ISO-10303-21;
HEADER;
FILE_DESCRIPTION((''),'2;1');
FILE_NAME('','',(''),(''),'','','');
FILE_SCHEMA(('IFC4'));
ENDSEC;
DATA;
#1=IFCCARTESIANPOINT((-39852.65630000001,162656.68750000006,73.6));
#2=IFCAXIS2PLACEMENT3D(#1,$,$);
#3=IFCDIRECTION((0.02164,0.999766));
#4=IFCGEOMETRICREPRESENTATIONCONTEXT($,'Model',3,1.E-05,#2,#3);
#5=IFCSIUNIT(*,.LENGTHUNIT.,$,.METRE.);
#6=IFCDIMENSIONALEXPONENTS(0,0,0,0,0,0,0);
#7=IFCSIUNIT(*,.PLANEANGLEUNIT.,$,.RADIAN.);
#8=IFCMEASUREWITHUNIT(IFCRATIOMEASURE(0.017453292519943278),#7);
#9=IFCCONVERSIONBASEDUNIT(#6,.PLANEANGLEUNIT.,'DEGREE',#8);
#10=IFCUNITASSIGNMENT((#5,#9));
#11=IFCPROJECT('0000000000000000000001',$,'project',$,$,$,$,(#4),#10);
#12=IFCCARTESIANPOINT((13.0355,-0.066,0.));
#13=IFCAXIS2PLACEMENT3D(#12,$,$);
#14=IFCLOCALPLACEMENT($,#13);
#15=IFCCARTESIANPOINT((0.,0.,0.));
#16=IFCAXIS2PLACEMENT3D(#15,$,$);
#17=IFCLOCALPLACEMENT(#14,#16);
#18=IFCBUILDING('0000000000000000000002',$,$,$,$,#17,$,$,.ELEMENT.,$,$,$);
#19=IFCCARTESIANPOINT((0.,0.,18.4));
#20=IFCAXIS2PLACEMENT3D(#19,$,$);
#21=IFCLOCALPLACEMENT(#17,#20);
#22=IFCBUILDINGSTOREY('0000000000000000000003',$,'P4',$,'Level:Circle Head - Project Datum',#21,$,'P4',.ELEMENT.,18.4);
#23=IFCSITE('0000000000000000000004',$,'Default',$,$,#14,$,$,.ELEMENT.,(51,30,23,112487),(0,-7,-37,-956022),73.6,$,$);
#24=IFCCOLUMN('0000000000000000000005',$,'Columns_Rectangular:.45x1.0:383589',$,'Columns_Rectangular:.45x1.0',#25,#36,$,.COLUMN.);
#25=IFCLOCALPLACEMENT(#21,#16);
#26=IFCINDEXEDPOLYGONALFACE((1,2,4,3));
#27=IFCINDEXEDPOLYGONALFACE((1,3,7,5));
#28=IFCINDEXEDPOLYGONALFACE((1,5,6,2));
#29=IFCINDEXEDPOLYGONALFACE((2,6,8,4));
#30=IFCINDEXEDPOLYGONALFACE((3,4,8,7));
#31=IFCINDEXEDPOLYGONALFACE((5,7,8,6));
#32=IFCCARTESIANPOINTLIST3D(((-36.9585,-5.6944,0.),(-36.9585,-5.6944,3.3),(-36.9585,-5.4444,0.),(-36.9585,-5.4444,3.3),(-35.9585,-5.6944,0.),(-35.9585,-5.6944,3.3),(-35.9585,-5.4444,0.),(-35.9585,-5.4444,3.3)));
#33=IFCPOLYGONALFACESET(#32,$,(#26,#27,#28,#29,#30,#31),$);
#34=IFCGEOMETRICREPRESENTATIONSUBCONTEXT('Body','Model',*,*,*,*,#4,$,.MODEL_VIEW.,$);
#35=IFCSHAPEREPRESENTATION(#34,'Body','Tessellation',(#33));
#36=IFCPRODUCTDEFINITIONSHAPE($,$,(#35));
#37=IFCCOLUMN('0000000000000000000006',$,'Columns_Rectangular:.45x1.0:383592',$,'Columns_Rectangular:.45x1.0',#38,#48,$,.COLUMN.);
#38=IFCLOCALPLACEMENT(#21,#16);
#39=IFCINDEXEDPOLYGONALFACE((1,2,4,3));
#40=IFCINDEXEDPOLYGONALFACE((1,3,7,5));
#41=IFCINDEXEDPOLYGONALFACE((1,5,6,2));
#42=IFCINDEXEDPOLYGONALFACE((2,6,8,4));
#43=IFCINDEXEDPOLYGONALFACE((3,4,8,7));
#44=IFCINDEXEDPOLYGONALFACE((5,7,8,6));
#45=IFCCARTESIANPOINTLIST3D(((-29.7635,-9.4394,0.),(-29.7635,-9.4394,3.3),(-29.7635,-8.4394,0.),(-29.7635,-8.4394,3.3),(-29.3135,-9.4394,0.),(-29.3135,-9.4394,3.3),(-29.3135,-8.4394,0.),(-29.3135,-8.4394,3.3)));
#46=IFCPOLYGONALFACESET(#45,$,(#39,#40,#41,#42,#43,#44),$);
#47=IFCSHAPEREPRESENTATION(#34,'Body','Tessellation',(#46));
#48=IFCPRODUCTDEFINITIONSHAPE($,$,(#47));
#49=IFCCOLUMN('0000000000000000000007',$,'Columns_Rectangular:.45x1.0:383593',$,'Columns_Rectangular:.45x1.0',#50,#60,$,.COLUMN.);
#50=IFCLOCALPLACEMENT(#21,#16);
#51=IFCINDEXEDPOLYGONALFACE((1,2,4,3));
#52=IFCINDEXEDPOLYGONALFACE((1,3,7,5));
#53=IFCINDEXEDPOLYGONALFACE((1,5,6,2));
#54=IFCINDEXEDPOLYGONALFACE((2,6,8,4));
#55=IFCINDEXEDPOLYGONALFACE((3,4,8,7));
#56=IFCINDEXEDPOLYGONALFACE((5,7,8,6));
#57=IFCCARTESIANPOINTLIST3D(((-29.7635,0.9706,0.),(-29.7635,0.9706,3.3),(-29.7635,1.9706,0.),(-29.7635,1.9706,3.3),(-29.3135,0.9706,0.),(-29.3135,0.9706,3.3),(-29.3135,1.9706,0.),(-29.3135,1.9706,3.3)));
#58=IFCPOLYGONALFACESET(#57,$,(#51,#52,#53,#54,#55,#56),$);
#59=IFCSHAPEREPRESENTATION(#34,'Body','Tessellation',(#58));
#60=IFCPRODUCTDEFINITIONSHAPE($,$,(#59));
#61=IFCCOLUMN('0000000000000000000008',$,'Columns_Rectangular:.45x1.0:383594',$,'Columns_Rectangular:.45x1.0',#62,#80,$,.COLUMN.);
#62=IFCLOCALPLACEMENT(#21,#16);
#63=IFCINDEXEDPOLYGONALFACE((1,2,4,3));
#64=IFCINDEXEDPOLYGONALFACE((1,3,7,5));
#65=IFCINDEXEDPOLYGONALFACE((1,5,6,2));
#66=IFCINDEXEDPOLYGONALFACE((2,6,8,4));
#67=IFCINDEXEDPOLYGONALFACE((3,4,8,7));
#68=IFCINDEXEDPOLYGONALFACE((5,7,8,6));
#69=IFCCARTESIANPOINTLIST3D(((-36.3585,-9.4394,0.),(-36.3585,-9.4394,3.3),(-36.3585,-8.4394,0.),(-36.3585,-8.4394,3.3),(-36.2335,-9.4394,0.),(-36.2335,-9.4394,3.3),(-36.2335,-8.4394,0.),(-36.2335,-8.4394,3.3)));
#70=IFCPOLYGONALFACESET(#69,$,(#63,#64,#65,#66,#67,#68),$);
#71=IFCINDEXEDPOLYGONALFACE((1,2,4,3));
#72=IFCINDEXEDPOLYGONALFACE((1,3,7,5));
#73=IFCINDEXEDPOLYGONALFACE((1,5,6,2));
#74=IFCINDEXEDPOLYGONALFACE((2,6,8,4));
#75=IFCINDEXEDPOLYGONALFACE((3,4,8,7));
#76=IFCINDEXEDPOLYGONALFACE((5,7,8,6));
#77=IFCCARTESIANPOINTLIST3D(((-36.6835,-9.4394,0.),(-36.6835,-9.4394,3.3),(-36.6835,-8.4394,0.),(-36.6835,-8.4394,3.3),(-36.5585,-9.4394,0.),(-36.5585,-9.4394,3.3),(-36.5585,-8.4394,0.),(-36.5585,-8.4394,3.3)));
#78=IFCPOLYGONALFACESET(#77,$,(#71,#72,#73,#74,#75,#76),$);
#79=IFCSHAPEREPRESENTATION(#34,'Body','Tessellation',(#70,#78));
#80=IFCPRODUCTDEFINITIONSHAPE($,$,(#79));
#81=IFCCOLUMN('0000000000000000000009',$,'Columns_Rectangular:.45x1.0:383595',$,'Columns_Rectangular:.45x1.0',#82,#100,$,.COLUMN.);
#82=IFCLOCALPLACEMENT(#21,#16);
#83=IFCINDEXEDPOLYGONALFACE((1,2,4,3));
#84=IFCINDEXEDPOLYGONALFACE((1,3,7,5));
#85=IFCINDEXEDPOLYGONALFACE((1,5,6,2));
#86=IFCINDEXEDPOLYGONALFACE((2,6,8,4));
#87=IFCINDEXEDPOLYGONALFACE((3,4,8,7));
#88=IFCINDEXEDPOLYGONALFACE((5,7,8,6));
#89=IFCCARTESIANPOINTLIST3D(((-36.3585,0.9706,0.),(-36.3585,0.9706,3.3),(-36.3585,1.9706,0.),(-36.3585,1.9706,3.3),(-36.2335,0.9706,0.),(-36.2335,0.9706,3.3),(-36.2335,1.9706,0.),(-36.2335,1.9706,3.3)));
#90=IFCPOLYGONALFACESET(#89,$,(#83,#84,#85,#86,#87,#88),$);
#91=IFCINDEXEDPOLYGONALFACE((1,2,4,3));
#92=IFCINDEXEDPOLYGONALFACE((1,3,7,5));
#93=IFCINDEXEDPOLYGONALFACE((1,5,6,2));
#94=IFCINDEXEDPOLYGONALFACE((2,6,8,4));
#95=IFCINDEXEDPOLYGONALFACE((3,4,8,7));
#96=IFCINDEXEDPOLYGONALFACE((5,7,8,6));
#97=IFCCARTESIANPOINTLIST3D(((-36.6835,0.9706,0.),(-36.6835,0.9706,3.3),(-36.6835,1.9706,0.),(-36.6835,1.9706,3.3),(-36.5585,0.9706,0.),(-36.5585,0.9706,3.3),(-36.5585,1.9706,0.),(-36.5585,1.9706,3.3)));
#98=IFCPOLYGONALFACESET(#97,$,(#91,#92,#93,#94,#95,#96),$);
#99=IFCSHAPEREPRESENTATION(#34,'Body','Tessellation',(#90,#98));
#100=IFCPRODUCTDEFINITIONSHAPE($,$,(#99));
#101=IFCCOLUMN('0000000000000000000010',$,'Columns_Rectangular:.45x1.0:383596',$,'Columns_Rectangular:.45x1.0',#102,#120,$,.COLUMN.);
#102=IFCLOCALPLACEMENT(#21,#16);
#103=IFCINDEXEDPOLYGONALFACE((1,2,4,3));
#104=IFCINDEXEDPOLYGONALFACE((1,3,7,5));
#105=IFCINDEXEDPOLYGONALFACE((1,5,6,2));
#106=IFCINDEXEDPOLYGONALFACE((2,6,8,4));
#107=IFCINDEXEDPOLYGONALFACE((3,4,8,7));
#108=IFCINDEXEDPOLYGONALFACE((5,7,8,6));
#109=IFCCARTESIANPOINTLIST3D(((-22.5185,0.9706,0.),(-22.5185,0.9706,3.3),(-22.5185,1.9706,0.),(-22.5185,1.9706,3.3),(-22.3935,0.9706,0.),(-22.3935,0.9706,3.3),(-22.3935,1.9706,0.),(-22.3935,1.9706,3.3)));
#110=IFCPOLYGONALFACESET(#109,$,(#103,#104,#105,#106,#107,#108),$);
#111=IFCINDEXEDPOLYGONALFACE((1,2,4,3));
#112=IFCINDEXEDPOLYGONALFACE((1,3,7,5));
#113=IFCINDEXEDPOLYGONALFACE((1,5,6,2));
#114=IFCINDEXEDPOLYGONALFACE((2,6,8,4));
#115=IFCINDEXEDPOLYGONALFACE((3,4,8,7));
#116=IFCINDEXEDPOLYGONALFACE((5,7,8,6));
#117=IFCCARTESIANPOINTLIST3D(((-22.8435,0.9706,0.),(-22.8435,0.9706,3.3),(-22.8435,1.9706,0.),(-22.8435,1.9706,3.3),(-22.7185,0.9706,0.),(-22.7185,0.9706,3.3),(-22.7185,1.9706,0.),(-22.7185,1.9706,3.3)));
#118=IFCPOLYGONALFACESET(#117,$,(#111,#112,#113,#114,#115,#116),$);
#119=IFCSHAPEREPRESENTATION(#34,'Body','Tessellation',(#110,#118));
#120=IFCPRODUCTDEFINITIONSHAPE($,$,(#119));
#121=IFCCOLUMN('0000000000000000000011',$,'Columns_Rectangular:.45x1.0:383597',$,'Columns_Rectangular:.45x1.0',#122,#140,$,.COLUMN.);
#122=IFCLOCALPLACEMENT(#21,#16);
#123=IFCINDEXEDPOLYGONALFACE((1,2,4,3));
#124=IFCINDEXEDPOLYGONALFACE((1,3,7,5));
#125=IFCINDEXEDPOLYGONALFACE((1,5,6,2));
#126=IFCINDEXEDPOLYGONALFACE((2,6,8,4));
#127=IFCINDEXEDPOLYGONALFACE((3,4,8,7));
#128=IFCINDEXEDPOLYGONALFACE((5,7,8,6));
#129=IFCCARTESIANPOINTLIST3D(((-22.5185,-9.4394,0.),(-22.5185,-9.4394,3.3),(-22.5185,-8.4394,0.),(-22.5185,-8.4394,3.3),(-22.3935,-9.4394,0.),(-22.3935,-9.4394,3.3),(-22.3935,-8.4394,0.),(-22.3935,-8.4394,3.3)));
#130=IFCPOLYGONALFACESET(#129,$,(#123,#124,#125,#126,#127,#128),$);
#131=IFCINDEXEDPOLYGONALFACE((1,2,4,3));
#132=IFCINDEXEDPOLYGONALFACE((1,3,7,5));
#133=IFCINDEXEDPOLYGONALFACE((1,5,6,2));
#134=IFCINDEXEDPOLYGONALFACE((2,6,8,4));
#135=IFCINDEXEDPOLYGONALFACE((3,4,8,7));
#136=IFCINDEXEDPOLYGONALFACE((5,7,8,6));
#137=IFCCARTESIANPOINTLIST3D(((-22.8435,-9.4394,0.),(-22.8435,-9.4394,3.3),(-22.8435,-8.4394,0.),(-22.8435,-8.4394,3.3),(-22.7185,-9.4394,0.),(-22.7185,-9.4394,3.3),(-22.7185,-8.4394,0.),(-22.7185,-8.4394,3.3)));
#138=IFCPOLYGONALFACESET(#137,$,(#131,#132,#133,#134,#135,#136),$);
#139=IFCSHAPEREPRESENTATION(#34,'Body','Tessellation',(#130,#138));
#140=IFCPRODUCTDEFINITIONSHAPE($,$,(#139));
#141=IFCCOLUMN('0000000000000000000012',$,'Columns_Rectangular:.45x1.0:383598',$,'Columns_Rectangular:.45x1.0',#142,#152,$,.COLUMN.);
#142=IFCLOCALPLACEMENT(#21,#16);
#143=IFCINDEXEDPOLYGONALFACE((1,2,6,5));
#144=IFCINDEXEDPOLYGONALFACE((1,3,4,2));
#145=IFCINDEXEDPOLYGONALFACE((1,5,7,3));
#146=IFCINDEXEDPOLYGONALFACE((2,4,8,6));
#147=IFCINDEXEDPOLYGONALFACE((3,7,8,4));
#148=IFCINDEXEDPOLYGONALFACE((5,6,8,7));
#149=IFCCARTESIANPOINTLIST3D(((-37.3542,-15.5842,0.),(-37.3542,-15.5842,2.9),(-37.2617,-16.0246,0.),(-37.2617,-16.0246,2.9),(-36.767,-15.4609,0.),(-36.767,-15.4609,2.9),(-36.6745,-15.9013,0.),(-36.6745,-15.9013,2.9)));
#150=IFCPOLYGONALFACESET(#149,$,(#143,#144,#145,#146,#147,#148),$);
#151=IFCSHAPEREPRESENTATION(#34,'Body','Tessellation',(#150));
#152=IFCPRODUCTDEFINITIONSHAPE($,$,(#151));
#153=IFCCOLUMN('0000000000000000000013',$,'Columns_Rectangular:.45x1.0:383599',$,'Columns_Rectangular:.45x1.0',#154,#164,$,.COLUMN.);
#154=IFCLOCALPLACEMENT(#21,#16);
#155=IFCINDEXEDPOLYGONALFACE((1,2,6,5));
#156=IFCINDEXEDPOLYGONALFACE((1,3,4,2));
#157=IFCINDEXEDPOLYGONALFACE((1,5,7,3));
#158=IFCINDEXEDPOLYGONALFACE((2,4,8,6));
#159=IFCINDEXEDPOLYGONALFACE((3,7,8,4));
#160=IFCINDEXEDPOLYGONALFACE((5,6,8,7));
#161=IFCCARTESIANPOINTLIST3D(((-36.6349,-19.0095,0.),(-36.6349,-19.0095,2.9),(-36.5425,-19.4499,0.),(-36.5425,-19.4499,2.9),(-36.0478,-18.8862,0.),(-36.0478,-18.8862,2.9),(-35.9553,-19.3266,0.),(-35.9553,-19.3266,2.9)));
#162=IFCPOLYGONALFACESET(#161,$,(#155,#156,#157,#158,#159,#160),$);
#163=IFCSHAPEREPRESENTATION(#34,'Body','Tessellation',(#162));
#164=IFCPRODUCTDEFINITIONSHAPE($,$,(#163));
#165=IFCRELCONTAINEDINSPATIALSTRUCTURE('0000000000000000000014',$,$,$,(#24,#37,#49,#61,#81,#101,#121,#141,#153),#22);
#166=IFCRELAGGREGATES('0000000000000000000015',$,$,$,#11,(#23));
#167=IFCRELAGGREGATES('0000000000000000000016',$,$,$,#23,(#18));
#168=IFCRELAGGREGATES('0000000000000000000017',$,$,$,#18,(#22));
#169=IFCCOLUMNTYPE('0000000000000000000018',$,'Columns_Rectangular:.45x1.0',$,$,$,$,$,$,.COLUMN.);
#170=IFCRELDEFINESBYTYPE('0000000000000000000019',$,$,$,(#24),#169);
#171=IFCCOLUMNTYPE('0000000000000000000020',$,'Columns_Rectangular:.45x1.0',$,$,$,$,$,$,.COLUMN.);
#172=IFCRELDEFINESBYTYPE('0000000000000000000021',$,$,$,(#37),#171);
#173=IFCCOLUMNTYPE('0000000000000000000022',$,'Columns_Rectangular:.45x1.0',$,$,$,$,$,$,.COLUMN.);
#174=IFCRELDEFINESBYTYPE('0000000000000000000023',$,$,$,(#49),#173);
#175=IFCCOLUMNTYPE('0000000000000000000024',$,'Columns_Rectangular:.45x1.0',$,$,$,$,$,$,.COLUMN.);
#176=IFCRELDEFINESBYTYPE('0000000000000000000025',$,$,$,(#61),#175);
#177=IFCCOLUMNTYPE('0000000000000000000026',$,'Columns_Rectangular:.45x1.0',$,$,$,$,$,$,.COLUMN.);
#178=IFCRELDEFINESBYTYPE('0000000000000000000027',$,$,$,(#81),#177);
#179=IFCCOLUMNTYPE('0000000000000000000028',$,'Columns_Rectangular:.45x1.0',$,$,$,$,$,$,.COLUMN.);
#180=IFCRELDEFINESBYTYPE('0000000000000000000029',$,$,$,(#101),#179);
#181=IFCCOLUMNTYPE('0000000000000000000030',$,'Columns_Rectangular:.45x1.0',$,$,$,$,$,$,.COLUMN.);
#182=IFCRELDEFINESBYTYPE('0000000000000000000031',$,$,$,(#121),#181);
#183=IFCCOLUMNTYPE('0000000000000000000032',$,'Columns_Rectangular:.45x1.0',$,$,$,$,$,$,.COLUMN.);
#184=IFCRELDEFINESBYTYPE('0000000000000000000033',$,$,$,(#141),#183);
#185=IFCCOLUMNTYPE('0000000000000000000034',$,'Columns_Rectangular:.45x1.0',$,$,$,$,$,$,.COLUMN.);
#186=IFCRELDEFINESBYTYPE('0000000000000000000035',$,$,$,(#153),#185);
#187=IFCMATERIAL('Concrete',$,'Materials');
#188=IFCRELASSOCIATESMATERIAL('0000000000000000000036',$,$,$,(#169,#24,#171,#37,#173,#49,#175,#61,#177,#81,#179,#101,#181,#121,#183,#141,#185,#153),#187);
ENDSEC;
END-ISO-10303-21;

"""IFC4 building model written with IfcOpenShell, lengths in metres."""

from ifc_helpers import new_model, entity, si_unit, converted_unit, direction, frame, origin, place, context, subcontext, project, spatial, indexed_curve, outline, extrude, source, transform, mapped, material, type_object, type_shapes, element, save


model = new_model("IFC4")

# Units and contexts
model_context = context("Model", 3, precision=1e-05, world=frame((-39852.65630000001, 162656.68750000006, 73.6)), true_north=direction((0.02164, 0.999766)))
body_context = subcontext(model_context, "Body", "Model", "MODEL_VIEW")
ifc_project = project(units=[si_unit("LENGTHUNIT", "METRE"), converted_unit("PLANEANGLEUNIT", "DEGREE", entity("IfcRatioMeasure", 0.017453292519943278), si_unit("PLANEANGLEUNIT", "RADIAN"), dimensions=[0, 0, 0, 0, 0, 0, 0])], contexts=[model_context])

# Site, building, storey
site_placement = place(None, frame((13.0355, -0.066, 0.0)))
site = spatial("IfcSite", under=ifc_project, at=site_placement, Name="Default", CompositionType="ELEMENT", RefLatitude=(51, 30, 23, 112487), RefLongitude=(0, -7, -37, -956022), RefElevation=73.6)
building_placement = place(site_placement, origin())
building = spatial("IfcBuilding", under=site, at=building_placement, CompositionType="ELEMENT")
storey_placement = place(building_placement, frame((0.0, 0.0, 18.4)))
storey = spatial("IfcBuildingStorey", under=building, at=storey_placement, Name="P4", ObjectType="Level:Circle Head - Project Datum", LongName="P4", CompositionType="ELEMENT", Elevation=18.4)

# Columns
ifc_material = material(Name="Concrete", Category="Materials")
column_type_1 = type_object("IfcColumnType", Name="Columns_Rectangular:.45x1.0", PredefinedType="COLUMN", material=ifc_material)
shared_shape_1 = source(origin(), body_context, "Body", "SweptSolid", [
    extrude(outline(indexed_curve([(-0.125, -0.5), (0.125, -0.5), (0.125, 0.5), (-0.125, 0.5), (-0.125, -0.5)], self_intersect=False)), frame((-36.4585, -5.5694, 18.4), z_axis=(0.0, 0.0, 1.0), x_axis=(0.0, -1.0, 0.0)), (0.0, 0.0, 1.0), 3.3),
])
type_shapes(column_type_1, [shared_shape_1])
column_1_placement = place(storey_placement, frame((0.0, 0.0, -18.4)))
element("IfcColumn", 1, at=column_1_placement, inside=storey, type_object=column_type_1, material=ifc_material, Name="Columns_Rectangular:.45x1.0:383589", ObjectType="Columns_Rectangular:.45x1.0", PredefinedType="COLUMN", context=body_context, shape_type="MappedRepresentation", body=[
    mapped(shared_shape_1, transform((0.0, 0.0, 0.0), scale=1.0)),
])
column_type_2 = type_object("IfcColumnType", Name="Columns_Rectangular:.45x1.0", PredefinedType="COLUMN", material=ifc_material)
shared_shape_2 = source(origin(), body_context, "Body", "SweptSolid", [
    extrude(outline(indexed_curve([(-0.5, -0.225), (0.5, -0.225), (0.5, 0.225), (-0.5, 0.225), (-0.5, -0.225)], self_intersect=False)), frame((-29.5385, -8.9394, 18.4), z_axis=(0.0, 0.0, 1.0), x_axis=(0.0, -1.0, 0.0)), (0.0, 0.0, 1.0), 3.3),
])
type_shapes(column_type_2, [shared_shape_2])
column_2_placement = place(storey_placement, frame((0.0, 0.0, -18.4)))
element("IfcColumn", 2, at=column_2_placement, inside=storey, type_object=column_type_2, material=ifc_material, Name="Columns_Rectangular:.45x1.0:383592", ObjectType="Columns_Rectangular:.45x1.0", PredefinedType="COLUMN", context=body_context, shape_type="MappedRepresentation", body=[
    mapped(shared_shape_2, transform((0.0, 0.0, 0.0), scale=1.0)),
])
column_type_3 = type_object("IfcColumnType", Name="Columns_Rectangular:.45x1.0", PredefinedType="COLUMN", material=ifc_material)
shared_shape_3 = source(origin(), body_context, "Body", "SweptSolid", [
    extrude(outline(indexed_curve([(-0.5, -0.225), (0.5, -0.225), (0.5, 0.225), (-0.5, 0.225), (-0.5, -0.225)], self_intersect=False)), frame((-29.5385, 1.4706, 18.4), z_axis=(0.0, 0.0, 1.0), x_axis=(0.0, -1.0, 0.0)), (0.0, 0.0, 1.0), 3.3),
])
type_shapes(column_type_3, [shared_shape_3])
column_3_placement = place(storey_placement, frame((0.0, 0.0, -18.4)))
element("IfcColumn", 3, at=column_3_placement, inside=storey, type_object=column_type_3, material=ifc_material, Name="Columns_Rectangular:.45x1.0:383593", ObjectType="Columns_Rectangular:.45x1.0", PredefinedType="COLUMN", context=body_context, shape_type="MappedRepresentation", body=[
    mapped(shared_shape_3, transform((0.0, 0.0, 0.0), scale=1.0)),
])
column_type_4 = type_object("IfcColumnType", Name="Columns_Rectangular:.45x1.0", PredefinedType="COLUMN", material=ifc_material)
shared_shape_4 = source(origin(), body_context, "Body", "SweptSolid", [
    extrude(outline(indexed_curve([(-0.5, -0.0625), (0.5, -0.0625), (0.5, 0.0625), (-0.5, 0.0625), (-0.5, -0.0625)], self_intersect=False)), frame((-36.296, -8.9394, 18.4), z_axis=(0.0, 0.0, 1.0), x_axis=(0.0, -1.0, 0.0)), (0.0, 0.0, 1.0), 3.3),
    extrude(outline(indexed_curve([(-0.5, -0.0625), (0.5, -0.0625), (0.5, 0.0625), (-0.5, 0.0625), (-0.5, -0.0625)], self_intersect=False)), frame((-36.621, -8.9394, 18.4), z_axis=(0.0, 0.0, 1.0), x_axis=(0.0, -1.0, 0.0)), (0.0, 0.0, 1.0), 3.3),
])
type_shapes(column_type_4, [shared_shape_4])
column_4_placement = place(storey_placement, frame((0.0, 0.0, -18.4)))
element("IfcColumn", 4, at=column_4_placement, inside=storey, type_object=column_type_4, material=ifc_material, Name="Columns_Rectangular:.45x1.0:383594", ObjectType="Columns_Rectangular:.45x1.0", PredefinedType="COLUMN", context=body_context, shape_type="MappedRepresentation", body=[
    mapped(shared_shape_4, transform((0.0, 0.0, 0.0), scale=1.0)),
])
column_type_5 = type_object("IfcColumnType", Name="Columns_Rectangular:.45x1.0", PredefinedType="COLUMN", material=ifc_material)
shared_shape_5 = source(origin(), body_context, "Body", "SweptSolid", [
    extrude(outline(indexed_curve([(-0.5, -0.0625), (0.5, -0.0625), (0.5, 0.0625), (-0.5, 0.0625), (-0.5, -0.0625)], self_intersect=False)), frame((-36.296, 1.4706, 18.4), z_axis=(0.0, 0.0, 1.0), x_axis=(0.0, -1.0, 0.0)), (0.0, 0.0, 1.0), 3.3),
    extrude(outline(indexed_curve([(-0.5, -0.0625), (0.5, -0.0625), (0.5, 0.0625), (-0.5, 0.0625), (-0.5, -0.0625)], self_intersect=False)), frame((-36.621, 1.4706, 18.4), z_axis=(0.0, 0.0, 1.0), x_axis=(0.0, -1.0, 0.0)), (0.0, 0.0, 1.0), 3.3),
])
type_shapes(column_type_5, [shared_shape_5])
column_5_placement = place(storey_placement, frame((0.0, 0.0, -18.4)))
element("IfcColumn", 5, at=column_5_placement, inside=storey, type_object=column_type_5, material=ifc_material, Name="Columns_Rectangular:.45x1.0:383595", ObjectType="Columns_Rectangular:.45x1.0", PredefinedType="COLUMN", context=body_context, shape_type="MappedRepresentation", body=[
    mapped(shared_shape_5, transform((0.0, 0.0, 0.0), scale=1.0)),
])
column_type_6 = type_object("IfcColumnType", Name="Columns_Rectangular:.45x1.0", PredefinedType="COLUMN", material=ifc_material)
shared_shape_6 = source(origin(), body_context, "Body", "SweptSolid", [
    extrude(outline(indexed_curve([(-0.5, -0.0625), (0.5, -0.0625), (0.5, 0.0625), (-0.5, 0.0625), (-0.5, -0.0625)], self_intersect=False)), frame((-22.456, 1.4706, 18.4), z_axis=(0.0, 0.0, 1.0), x_axis=(0.0, -1.0, 0.0)), (0.0, 0.0, 1.0), 3.3),
    extrude(outline(indexed_curve([(-0.5, -0.0625), (0.5, -0.0625), (0.5, 0.0625), (-0.5, 0.0625), (-0.5, -0.0625)], self_intersect=False)), frame((-22.781, 1.4706, 18.4), z_axis=(0.0, 0.0, 1.0), x_axis=(0.0, -1.0, 0.0)), (0.0, 0.0, 1.0), 3.3),
])
type_shapes(column_type_6, [shared_shape_6])
column_6_placement = place(storey_placement, frame((0.0, 0.0, -18.4)))
element("IfcColumn", 6, at=column_6_placement, inside=storey, type_object=column_type_6, material=ifc_material, Name="Columns_Rectangular:.45x1.0:383596", ObjectType="Columns_Rectangular:.45x1.0", PredefinedType="COLUMN", context=body_context, shape_type="MappedRepresentation", body=[
    mapped(shared_shape_6, transform((0.0, 0.0, 0.0), scale=1.0)),
])
column_type_7 = type_object("IfcColumnType", Name="Columns_Rectangular:.45x1.0", PredefinedType="COLUMN", material=ifc_material)
shared_shape_7 = source(origin(), body_context, "Body", "SweptSolid", [
    extrude(outline(indexed_curve([(-0.5, -0.0625), (0.5, -0.0625), (0.5, 0.0625), (-0.5, 0.0625), (-0.5, -0.0625)], self_intersect=False)), frame((-22.456, -8.9394, 18.4), z_axis=(0.0, 0.0, 1.0), x_axis=(0.0, -1.0, 0.0)), (0.0, 0.0, 1.0), 3.3),
    extrude(outline(indexed_curve([(-0.5, -0.0625), (0.5, -0.0625), (0.5, 0.0625), (-0.5, 0.0625), (-0.5, -0.0625)], self_intersect=False)), frame((-22.781, -8.9394, 18.4), z_axis=(0.0, 0.0, 1.0), x_axis=(0.0, -1.0, 0.0)), (0.0, 0.0, 1.0), 3.3),
])
type_shapes(column_type_7, [shared_shape_7])
column_7_placement = place(storey_placement, frame((0.0, 0.0, -18.4)))
element("IfcColumn", 7, at=column_7_placement, inside=storey, type_object=column_type_7, material=ifc_material, Name="Columns_Rectangular:.45x1.0:383597", ObjectType="Columns_Rectangular:.45x1.0", PredefinedType="COLUMN", context=body_context, shape_type="MappedRepresentation", body=[
    mapped(shared_shape_7, transform((0.0, 0.0, 0.0), scale=1.0)),
])
column_type_8 = type_object("IfcColumnType", Name="Columns_Rectangular:.45x1.0", PredefinedType="COLUMN", material=ifc_material)
shared_shape_8 = source(origin(), body_context, "Body", "SweptSolid", [
    extrude(outline(indexed_curve([(-0.3, -0.225), (0.3, -0.225), (0.3, 0.225), (-0.3, 0.225), (-0.3, -0.225)], self_intersect=False)), frame((-37.0144, -15.7427, 18.4), z_axis=(0.0, 0.0, 1.0), x_axis=(-0.978657, -0.2055, 0.0)), (0.0, 0.0, 1.0), 2.9),
])
type_shapes(column_type_8, [shared_shape_8])
column_8_placement = place(storey_placement, frame((0.0, 0.0, -18.4)))
element("IfcColumn", 8, at=column_8_placement, inside=storey, type_object=column_type_8, material=ifc_material, Name="Columns_Rectangular:.45x1.0:383598", ObjectType="Columns_Rectangular:.45x1.0", PredefinedType="COLUMN", context=body_context, shape_type="MappedRepresentation", body=[
    mapped(shared_shape_8, transform((0.0, 0.0, 0.0), scale=1.0)),
])
column_type_9 = type_object("IfcColumnType", Name="Columns_Rectangular:.45x1.0", PredefinedType="COLUMN", material=ifc_material)
shared_shape_9 = source(origin(), body_context, "Body", "SweptSolid", [
    extrude(outline(indexed_curve([(-0.3, -0.225), (0.3, -0.225), (0.3, 0.225), (-0.3, 0.225), (-0.3, -0.225)], self_intersect=False)), frame((-36.2951, -19.168, 18.4), z_axis=(0.0, 0.0, 1.0), x_axis=(-0.978657, -0.2055, 0.0)), (0.0, 0.0, 1.0), 2.9),
])
type_shapes(column_type_9, [shared_shape_9])
column_9_placement = place(storey_placement, frame((0.0, 0.0, -18.4)))
element("IfcColumn", 9, at=column_9_placement, inside=storey, type_object=column_type_9, material=ifc_material, Name="Columns_Rectangular:.45x1.0:383599", ObjectType="Columns_Rectangular:.45x1.0", PredefinedType="COLUMN", context=body_context, shape_type="MappedRepresentation", body=[
    mapped(shared_shape_9, transform((0.0, 0.0, 0.0), scale=1.0)),
])

save(model, "model.ifc")
